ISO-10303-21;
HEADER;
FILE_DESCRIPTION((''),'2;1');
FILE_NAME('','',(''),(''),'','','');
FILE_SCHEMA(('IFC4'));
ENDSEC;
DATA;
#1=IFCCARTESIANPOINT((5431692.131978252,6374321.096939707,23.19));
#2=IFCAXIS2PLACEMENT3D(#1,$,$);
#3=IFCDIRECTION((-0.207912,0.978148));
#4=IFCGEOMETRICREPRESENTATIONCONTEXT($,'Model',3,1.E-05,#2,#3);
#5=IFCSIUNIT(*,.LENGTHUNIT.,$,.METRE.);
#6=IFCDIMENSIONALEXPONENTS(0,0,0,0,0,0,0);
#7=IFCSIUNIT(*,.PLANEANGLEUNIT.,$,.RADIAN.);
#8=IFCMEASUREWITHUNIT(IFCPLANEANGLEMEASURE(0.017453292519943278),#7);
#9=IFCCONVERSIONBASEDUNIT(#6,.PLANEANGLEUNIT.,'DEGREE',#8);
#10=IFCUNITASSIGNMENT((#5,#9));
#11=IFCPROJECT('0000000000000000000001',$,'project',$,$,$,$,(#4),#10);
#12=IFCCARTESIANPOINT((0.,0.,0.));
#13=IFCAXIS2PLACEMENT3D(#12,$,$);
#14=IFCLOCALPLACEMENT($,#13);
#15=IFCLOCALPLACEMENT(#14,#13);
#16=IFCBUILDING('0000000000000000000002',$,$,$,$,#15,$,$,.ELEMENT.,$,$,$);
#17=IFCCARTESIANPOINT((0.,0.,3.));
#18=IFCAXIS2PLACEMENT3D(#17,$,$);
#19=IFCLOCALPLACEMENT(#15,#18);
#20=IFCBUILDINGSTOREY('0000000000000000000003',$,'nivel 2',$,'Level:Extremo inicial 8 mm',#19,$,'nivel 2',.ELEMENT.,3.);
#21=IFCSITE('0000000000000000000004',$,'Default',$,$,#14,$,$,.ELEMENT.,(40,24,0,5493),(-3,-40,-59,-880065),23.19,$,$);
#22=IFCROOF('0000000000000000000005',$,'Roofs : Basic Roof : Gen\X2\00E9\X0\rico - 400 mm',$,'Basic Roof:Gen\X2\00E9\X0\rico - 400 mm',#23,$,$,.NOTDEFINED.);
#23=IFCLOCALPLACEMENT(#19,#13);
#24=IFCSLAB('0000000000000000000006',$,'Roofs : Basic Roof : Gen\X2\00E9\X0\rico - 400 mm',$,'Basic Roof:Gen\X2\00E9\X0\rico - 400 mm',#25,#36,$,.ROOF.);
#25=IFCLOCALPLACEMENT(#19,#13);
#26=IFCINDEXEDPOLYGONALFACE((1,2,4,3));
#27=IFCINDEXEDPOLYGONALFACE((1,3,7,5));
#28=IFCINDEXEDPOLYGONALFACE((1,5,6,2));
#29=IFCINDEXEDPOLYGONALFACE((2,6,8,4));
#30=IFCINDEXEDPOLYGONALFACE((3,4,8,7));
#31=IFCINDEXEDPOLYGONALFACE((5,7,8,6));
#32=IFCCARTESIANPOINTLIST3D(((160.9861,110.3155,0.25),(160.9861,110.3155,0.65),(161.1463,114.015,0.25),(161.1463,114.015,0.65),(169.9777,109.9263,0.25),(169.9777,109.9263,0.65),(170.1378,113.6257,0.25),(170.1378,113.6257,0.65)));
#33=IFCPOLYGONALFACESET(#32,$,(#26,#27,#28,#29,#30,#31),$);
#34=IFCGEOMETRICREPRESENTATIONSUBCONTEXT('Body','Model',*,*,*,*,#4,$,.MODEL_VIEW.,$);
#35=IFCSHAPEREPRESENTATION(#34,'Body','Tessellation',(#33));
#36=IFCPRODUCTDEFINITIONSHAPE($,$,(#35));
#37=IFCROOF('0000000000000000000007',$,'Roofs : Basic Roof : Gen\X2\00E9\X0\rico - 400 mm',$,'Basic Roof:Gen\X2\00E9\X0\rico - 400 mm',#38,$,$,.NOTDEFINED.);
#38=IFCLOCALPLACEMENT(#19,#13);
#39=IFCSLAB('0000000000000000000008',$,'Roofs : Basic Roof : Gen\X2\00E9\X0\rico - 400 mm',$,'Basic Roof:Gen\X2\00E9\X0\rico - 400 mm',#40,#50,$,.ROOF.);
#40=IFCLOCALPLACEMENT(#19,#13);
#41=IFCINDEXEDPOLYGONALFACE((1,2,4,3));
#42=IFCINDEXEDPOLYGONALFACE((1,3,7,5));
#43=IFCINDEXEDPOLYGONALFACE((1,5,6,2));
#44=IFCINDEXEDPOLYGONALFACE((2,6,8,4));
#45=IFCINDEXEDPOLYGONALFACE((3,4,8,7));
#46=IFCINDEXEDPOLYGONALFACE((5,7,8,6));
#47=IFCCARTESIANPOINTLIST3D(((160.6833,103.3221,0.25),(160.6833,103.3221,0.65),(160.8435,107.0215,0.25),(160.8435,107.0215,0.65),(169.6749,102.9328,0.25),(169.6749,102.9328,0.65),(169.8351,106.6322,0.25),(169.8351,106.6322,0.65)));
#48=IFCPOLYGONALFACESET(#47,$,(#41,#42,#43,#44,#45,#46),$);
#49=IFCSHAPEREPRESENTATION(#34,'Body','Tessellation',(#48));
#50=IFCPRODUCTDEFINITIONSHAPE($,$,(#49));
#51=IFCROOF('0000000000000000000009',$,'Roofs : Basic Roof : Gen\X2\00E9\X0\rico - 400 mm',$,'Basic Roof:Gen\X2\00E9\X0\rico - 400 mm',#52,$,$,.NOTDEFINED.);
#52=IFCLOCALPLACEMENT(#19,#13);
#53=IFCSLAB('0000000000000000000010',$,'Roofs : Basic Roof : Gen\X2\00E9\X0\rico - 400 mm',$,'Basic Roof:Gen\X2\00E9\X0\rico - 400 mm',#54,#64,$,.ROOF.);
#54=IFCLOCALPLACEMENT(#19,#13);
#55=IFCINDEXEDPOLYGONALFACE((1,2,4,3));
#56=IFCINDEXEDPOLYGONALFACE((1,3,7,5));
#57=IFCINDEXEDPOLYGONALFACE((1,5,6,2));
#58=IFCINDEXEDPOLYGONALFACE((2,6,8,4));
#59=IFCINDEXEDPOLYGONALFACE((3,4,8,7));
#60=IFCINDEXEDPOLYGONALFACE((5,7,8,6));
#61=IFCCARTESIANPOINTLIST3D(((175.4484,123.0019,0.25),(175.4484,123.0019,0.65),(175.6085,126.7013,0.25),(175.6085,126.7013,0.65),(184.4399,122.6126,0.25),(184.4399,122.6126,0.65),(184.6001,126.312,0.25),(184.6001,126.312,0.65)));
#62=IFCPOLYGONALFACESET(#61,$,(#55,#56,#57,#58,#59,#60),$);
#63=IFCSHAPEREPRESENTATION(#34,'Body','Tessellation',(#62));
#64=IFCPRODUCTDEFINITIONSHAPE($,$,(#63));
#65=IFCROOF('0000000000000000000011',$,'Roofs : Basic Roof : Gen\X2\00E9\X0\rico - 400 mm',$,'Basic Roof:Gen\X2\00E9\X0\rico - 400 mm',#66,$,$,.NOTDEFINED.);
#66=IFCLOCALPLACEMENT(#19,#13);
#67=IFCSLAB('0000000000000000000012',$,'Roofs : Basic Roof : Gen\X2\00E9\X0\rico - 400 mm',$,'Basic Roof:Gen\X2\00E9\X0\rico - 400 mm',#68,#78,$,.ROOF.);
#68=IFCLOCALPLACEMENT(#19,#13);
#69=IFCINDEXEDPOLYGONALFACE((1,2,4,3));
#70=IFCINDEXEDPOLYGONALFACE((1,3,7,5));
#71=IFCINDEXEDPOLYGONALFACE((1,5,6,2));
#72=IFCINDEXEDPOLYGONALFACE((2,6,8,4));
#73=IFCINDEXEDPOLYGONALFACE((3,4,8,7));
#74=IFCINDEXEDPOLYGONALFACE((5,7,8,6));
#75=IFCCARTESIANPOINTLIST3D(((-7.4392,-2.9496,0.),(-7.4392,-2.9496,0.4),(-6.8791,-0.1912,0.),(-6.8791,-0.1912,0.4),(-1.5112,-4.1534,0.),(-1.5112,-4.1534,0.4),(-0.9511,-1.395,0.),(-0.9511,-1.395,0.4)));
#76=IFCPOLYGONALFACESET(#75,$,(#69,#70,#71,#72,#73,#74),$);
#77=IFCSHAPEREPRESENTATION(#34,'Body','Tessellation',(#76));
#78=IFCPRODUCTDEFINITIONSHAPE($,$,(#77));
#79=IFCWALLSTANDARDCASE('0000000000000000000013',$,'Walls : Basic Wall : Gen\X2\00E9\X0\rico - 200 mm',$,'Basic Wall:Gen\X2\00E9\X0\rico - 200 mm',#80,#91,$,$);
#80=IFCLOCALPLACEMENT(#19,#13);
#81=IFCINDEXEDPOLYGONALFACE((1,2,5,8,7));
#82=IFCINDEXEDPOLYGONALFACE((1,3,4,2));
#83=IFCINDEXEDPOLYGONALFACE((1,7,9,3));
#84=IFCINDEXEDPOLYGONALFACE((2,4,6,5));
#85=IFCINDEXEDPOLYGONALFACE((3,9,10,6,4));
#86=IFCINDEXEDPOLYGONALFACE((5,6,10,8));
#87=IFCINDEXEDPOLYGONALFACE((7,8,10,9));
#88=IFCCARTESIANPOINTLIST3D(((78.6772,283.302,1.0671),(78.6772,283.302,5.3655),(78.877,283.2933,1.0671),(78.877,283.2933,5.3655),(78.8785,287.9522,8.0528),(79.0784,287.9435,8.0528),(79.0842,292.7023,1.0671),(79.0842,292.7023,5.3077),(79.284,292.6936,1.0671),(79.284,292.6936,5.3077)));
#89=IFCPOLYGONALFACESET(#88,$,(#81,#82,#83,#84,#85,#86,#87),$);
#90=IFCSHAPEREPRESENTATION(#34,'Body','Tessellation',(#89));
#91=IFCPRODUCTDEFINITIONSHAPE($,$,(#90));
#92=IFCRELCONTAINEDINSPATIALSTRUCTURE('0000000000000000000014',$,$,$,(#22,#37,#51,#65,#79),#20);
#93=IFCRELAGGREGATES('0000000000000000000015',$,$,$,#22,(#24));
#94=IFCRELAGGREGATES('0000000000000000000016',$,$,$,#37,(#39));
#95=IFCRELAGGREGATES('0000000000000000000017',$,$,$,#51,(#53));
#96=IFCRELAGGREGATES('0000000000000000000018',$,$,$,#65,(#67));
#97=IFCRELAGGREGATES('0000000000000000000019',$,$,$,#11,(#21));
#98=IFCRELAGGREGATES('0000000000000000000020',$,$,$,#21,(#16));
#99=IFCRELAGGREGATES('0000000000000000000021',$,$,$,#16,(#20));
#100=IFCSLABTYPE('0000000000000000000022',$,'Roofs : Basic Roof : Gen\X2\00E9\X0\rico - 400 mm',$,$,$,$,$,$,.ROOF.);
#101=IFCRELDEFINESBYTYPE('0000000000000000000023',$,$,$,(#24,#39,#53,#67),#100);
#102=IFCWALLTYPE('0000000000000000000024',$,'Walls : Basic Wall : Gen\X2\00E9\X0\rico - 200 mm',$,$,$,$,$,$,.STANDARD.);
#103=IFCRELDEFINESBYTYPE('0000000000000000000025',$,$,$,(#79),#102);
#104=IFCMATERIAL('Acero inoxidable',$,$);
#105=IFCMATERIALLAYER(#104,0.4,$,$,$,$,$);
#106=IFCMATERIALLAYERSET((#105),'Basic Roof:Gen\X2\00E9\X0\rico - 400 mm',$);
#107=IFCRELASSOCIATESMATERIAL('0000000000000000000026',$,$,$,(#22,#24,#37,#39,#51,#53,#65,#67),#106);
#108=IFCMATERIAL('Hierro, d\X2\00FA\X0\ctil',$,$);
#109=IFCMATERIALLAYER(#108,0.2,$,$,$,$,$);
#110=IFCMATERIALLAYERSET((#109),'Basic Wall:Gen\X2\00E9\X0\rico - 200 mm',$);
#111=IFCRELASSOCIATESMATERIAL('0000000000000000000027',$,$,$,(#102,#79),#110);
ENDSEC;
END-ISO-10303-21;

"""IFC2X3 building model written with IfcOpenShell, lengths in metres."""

from ifc_helpers import new_model, entity, si_unit, converted_unit, direction, frame, frame_2d, origin, place, context, subcontext, project, spatial, polyline, rectangle, extrude, clip, bounded_halfspace, material, layer, layer_set, layer_usage, type_object, element, aggregate, save


model = new_model("IFC2X3")

# Units and contexts
model_context = context("Model", 3, precision=1e-05, world=frame((5431692.131978252, 6374321.096939707, 23.19)), true_north=direction((-0.207912, 0.978148)))
body_context = subcontext(model_context, "Body", "Model", "MODEL_VIEW")
ifc_project = project(units=[si_unit("LENGTHUNIT", "METRE"), converted_unit("PLANEANGLEUNIT", "DEGREE", entity("IfcPlaneAngleMeasure", 0.017453292519943278), si_unit("PLANEANGLEUNIT", "RADIAN"), dimensions=[0, 0, 0, 0, 0, 0, 0])], contexts=[model_context])

# Site, building, storey
site_placement = place(None, origin())
site = spatial("IfcSite", under=ifc_project, at=site_placement, Name="Default", CompositionType="ELEMENT", RefLatitude=(40, 24, 0, 5493), RefLongitude=(-3, -40, -59, -880065), RefElevation=23.19)
building_placement = place(site_placement, origin())
building = spatial("IfcBuilding", under=site, at=building_placement, CompositionType="ELEMENT")
storey_placement = place(building_placement, frame((0.0, 0.0, 3.0)))
storey = spatial("IfcBuildingStorey", under=building, at=storey_placement, Name="nivel 2", ObjectType="Level:Extremo inicial 8 mm", LongName="nivel 2", CompositionType="ELEMENT", Elevation=3.0)

# Shared definitions
ifc_material_1 = material(Name="Acero inoxidable")
ifc_layer_1 = layer(ifc_material_1, 0.4)
ifc_layer_set_1 = layer_set([ifc_layer_1], Name="Basic Roof:Genérico - 400 mm")
slab_type = type_object("IfcSlabType", Name="Roofs : Basic Roof : Genérico - 400 mm", PredefinedType="ROOF")

# Roofs, slabs
roof_1_placement = place(storey_placement, frame((160.9861, 109.9263, 0.25)))
roof_1 = element("IfcRoof", 1, at=roof_1_placement, inside=storey, material=ifc_layer_set_1, Name="Roofs : Basic Roof : Genérico - 400 mm", ObjectType="Basic Roof:Genérico - 400 mm", ShapeType="NOTDEFINED")
slab_1_placement = place(roof_1_placement, origin())
slab_1 = element("IfcSlab", 2, at=slab_1_placement, type_object=slab_type, material=ifc_layer_set_1, Name="Roofs : Basic Roof : Genérico - 400 mm", ObjectType="Basic Roof:Genérico - 400 mm", PredefinedType="ROOF", context=body_context, shape_type="SweptSolid", body=[
    extrude(rectangle(XDim=3.7029, YDim=9.0, at=frame_2d((0.0, 0.0), x_axis=(0.043255, 0.999064))), frame((4.5759, 2.0444, 0.0)), (0.0, 0.0, 1.0), 0.4),
])
aggregate(roof_1, [slab_1])
roof_2_placement = place(storey_placement, frame((160.6833, 102.9328, 0.25)))
roof_2 = element("IfcRoof", 3, at=roof_2_placement, inside=storey, material=ifc_layer_set_1, Name="Roofs : Basic Roof : Genérico - 400 mm", ObjectType="Basic Roof:Genérico - 400 mm", ShapeType="NOTDEFINED")
slab_2_placement = place(roof_2_placement, origin())
slab_2 = element("IfcSlab", 4, at=slab_2_placement, type_object=slab_type, material=ifc_layer_set_1, Name="Roofs : Basic Roof : Genérico - 400 mm", ObjectType="Basic Roof:Genérico - 400 mm", PredefinedType="ROOF", context=body_context, shape_type="SweptSolid", body=[
    extrude(rectangle(XDim=3.7029, YDim=9.0, at=frame_2d((0.0, 0.0), x_axis=(0.043255, 0.999064))), frame((4.5759, 2.0444, 0.0)), (0.0, 0.0, 1.0), 0.4),
])
aggregate(roof_2, [slab_2])
roof_3_placement = place(storey_placement, frame((175.4484, 122.6126, 0.25)))
roof_3 = element("IfcRoof", 5, at=roof_3_placement, inside=storey, material=ifc_layer_set_1, Name="Roofs : Basic Roof : Genérico - 400 mm", ObjectType="Basic Roof:Genérico - 400 mm", ShapeType="NOTDEFINED")
slab_3_placement = place(roof_3_placement, origin())
slab_3 = element("IfcSlab", 6, at=slab_3_placement, type_object=slab_type, material=ifc_layer_set_1, Name="Roofs : Basic Roof : Genérico - 400 mm", ObjectType="Basic Roof:Genérico - 400 mm", PredefinedType="ROOF", context=body_context, shape_type="SweptSolid", body=[
    extrude(rectangle(XDim=3.7029, YDim=9.0, at=frame_2d((0.0, 0.0), x_axis=(0.043255, 0.999064))), frame((4.5759, 2.0444, 0.0)), (0.0, 0.0, 1.0), 0.4),
])
aggregate(roof_3, [slab_3])
roof_4_placement = place(storey_placement, frame((-7.4392, -4.1534, 0.0)))
roof_4 = element("IfcRoof", 7, at=roof_4_placement, inside=storey, material=ifc_layer_set_1, Name="Roofs : Basic Roof : Genérico - 400 mm", ObjectType="Basic Roof:Genérico - 400 mm", ShapeType="NOTDEFINED")
slab_4_placement = place(roof_4_placement, origin())
slab_4 = element("IfcSlab", 8, at=slab_4_placement, type_object=slab_type, material=ifc_layer_set_1, Name="Roofs : Basic Roof : Genérico - 400 mm", ObjectType="Basic Roof:Genérico - 400 mm", PredefinedType="ROOF", context=body_context, shape_type="SweptSolid", body=[
    extrude(rectangle(XDim=6.049, YDim=2.8147, at=frame_2d((0.0, 0.0), x_axis=(-0.979997, 0.19901))), frame((3.2441, 1.9811, 0.0)), (0.0, 0.0, 1.0), 0.4),
])
aggregate(roof_4, [slab_4])

# Wall
ifc_material_2 = material(Name="Hierro, dúctil")
ifc_layer_2 = layer(ifc_material_2, 0.2)
ifc_layer_set_2 = layer_set([ifc_layer_2], Name="Basic Wall:Genérico - 200 mm")
ifc_layer_usage = layer_usage(ifc_layer_set_2, "AXIS2", "NEGATIVE", 0.1)
wall_type = type_object("IfcWallType", Name="Walls : Basic Wall : Genérico - 200 mm", PredefinedType="STANDARD", material=ifc_layer_set_2)
wall_placement = place(storey_placement, frame((78.7771, 283.2977, 1.0671), z_axis=(0.0, 0.0, 1.0), x_axis=(0.043255, 0.999064, 0.0)))
element("IfcWallStandardCase", 9, at=wall_placement, inside=storey, type_object=wall_type, material=ifc_layer_usage, Name="Walls : Basic Wall : Genérico - 200 mm", ObjectType="Basic Wall:Genérico - 200 mm", context=body_context, shape_type="Clipping", body=[
    clip(clip(extrude(rectangle(XDim=9.4091, YDim=0.2, at=frame_2d((4.7046, 0.0), x_axis=(-1.0, 0.0))), origin(), (0.0, 0.0, 1.0), 6.9857), bounded_halfspace(frame((4.6546, -0.1, 6.9857), z_axis=(0.5, 0.0, 0.866025), x_axis=(0.0, 1.0, 0.0)), False, frame((4.6546, -0.1, 6.9857)), polyline([(0.0, 0.0), (4.7546, 0.0), (4.7546, 0.2), (0.0, 0.2), (0.0, 0.0)]))), bounded_halfspace(frame((0.0, -0.1, 4.2984), z_axis=(-0.5, 0.0, 0.866025), x_axis=(0.0, -1.0, 0.0)), False, frame((0.0, -0.1, 4.2984)), polyline([(0.0, 0.0), (4.6546, 0.0), (4.6546, 0.2), (0.0, 0.2), (0.0, 0.0)]))),
])

save(model, "model.ifc")
